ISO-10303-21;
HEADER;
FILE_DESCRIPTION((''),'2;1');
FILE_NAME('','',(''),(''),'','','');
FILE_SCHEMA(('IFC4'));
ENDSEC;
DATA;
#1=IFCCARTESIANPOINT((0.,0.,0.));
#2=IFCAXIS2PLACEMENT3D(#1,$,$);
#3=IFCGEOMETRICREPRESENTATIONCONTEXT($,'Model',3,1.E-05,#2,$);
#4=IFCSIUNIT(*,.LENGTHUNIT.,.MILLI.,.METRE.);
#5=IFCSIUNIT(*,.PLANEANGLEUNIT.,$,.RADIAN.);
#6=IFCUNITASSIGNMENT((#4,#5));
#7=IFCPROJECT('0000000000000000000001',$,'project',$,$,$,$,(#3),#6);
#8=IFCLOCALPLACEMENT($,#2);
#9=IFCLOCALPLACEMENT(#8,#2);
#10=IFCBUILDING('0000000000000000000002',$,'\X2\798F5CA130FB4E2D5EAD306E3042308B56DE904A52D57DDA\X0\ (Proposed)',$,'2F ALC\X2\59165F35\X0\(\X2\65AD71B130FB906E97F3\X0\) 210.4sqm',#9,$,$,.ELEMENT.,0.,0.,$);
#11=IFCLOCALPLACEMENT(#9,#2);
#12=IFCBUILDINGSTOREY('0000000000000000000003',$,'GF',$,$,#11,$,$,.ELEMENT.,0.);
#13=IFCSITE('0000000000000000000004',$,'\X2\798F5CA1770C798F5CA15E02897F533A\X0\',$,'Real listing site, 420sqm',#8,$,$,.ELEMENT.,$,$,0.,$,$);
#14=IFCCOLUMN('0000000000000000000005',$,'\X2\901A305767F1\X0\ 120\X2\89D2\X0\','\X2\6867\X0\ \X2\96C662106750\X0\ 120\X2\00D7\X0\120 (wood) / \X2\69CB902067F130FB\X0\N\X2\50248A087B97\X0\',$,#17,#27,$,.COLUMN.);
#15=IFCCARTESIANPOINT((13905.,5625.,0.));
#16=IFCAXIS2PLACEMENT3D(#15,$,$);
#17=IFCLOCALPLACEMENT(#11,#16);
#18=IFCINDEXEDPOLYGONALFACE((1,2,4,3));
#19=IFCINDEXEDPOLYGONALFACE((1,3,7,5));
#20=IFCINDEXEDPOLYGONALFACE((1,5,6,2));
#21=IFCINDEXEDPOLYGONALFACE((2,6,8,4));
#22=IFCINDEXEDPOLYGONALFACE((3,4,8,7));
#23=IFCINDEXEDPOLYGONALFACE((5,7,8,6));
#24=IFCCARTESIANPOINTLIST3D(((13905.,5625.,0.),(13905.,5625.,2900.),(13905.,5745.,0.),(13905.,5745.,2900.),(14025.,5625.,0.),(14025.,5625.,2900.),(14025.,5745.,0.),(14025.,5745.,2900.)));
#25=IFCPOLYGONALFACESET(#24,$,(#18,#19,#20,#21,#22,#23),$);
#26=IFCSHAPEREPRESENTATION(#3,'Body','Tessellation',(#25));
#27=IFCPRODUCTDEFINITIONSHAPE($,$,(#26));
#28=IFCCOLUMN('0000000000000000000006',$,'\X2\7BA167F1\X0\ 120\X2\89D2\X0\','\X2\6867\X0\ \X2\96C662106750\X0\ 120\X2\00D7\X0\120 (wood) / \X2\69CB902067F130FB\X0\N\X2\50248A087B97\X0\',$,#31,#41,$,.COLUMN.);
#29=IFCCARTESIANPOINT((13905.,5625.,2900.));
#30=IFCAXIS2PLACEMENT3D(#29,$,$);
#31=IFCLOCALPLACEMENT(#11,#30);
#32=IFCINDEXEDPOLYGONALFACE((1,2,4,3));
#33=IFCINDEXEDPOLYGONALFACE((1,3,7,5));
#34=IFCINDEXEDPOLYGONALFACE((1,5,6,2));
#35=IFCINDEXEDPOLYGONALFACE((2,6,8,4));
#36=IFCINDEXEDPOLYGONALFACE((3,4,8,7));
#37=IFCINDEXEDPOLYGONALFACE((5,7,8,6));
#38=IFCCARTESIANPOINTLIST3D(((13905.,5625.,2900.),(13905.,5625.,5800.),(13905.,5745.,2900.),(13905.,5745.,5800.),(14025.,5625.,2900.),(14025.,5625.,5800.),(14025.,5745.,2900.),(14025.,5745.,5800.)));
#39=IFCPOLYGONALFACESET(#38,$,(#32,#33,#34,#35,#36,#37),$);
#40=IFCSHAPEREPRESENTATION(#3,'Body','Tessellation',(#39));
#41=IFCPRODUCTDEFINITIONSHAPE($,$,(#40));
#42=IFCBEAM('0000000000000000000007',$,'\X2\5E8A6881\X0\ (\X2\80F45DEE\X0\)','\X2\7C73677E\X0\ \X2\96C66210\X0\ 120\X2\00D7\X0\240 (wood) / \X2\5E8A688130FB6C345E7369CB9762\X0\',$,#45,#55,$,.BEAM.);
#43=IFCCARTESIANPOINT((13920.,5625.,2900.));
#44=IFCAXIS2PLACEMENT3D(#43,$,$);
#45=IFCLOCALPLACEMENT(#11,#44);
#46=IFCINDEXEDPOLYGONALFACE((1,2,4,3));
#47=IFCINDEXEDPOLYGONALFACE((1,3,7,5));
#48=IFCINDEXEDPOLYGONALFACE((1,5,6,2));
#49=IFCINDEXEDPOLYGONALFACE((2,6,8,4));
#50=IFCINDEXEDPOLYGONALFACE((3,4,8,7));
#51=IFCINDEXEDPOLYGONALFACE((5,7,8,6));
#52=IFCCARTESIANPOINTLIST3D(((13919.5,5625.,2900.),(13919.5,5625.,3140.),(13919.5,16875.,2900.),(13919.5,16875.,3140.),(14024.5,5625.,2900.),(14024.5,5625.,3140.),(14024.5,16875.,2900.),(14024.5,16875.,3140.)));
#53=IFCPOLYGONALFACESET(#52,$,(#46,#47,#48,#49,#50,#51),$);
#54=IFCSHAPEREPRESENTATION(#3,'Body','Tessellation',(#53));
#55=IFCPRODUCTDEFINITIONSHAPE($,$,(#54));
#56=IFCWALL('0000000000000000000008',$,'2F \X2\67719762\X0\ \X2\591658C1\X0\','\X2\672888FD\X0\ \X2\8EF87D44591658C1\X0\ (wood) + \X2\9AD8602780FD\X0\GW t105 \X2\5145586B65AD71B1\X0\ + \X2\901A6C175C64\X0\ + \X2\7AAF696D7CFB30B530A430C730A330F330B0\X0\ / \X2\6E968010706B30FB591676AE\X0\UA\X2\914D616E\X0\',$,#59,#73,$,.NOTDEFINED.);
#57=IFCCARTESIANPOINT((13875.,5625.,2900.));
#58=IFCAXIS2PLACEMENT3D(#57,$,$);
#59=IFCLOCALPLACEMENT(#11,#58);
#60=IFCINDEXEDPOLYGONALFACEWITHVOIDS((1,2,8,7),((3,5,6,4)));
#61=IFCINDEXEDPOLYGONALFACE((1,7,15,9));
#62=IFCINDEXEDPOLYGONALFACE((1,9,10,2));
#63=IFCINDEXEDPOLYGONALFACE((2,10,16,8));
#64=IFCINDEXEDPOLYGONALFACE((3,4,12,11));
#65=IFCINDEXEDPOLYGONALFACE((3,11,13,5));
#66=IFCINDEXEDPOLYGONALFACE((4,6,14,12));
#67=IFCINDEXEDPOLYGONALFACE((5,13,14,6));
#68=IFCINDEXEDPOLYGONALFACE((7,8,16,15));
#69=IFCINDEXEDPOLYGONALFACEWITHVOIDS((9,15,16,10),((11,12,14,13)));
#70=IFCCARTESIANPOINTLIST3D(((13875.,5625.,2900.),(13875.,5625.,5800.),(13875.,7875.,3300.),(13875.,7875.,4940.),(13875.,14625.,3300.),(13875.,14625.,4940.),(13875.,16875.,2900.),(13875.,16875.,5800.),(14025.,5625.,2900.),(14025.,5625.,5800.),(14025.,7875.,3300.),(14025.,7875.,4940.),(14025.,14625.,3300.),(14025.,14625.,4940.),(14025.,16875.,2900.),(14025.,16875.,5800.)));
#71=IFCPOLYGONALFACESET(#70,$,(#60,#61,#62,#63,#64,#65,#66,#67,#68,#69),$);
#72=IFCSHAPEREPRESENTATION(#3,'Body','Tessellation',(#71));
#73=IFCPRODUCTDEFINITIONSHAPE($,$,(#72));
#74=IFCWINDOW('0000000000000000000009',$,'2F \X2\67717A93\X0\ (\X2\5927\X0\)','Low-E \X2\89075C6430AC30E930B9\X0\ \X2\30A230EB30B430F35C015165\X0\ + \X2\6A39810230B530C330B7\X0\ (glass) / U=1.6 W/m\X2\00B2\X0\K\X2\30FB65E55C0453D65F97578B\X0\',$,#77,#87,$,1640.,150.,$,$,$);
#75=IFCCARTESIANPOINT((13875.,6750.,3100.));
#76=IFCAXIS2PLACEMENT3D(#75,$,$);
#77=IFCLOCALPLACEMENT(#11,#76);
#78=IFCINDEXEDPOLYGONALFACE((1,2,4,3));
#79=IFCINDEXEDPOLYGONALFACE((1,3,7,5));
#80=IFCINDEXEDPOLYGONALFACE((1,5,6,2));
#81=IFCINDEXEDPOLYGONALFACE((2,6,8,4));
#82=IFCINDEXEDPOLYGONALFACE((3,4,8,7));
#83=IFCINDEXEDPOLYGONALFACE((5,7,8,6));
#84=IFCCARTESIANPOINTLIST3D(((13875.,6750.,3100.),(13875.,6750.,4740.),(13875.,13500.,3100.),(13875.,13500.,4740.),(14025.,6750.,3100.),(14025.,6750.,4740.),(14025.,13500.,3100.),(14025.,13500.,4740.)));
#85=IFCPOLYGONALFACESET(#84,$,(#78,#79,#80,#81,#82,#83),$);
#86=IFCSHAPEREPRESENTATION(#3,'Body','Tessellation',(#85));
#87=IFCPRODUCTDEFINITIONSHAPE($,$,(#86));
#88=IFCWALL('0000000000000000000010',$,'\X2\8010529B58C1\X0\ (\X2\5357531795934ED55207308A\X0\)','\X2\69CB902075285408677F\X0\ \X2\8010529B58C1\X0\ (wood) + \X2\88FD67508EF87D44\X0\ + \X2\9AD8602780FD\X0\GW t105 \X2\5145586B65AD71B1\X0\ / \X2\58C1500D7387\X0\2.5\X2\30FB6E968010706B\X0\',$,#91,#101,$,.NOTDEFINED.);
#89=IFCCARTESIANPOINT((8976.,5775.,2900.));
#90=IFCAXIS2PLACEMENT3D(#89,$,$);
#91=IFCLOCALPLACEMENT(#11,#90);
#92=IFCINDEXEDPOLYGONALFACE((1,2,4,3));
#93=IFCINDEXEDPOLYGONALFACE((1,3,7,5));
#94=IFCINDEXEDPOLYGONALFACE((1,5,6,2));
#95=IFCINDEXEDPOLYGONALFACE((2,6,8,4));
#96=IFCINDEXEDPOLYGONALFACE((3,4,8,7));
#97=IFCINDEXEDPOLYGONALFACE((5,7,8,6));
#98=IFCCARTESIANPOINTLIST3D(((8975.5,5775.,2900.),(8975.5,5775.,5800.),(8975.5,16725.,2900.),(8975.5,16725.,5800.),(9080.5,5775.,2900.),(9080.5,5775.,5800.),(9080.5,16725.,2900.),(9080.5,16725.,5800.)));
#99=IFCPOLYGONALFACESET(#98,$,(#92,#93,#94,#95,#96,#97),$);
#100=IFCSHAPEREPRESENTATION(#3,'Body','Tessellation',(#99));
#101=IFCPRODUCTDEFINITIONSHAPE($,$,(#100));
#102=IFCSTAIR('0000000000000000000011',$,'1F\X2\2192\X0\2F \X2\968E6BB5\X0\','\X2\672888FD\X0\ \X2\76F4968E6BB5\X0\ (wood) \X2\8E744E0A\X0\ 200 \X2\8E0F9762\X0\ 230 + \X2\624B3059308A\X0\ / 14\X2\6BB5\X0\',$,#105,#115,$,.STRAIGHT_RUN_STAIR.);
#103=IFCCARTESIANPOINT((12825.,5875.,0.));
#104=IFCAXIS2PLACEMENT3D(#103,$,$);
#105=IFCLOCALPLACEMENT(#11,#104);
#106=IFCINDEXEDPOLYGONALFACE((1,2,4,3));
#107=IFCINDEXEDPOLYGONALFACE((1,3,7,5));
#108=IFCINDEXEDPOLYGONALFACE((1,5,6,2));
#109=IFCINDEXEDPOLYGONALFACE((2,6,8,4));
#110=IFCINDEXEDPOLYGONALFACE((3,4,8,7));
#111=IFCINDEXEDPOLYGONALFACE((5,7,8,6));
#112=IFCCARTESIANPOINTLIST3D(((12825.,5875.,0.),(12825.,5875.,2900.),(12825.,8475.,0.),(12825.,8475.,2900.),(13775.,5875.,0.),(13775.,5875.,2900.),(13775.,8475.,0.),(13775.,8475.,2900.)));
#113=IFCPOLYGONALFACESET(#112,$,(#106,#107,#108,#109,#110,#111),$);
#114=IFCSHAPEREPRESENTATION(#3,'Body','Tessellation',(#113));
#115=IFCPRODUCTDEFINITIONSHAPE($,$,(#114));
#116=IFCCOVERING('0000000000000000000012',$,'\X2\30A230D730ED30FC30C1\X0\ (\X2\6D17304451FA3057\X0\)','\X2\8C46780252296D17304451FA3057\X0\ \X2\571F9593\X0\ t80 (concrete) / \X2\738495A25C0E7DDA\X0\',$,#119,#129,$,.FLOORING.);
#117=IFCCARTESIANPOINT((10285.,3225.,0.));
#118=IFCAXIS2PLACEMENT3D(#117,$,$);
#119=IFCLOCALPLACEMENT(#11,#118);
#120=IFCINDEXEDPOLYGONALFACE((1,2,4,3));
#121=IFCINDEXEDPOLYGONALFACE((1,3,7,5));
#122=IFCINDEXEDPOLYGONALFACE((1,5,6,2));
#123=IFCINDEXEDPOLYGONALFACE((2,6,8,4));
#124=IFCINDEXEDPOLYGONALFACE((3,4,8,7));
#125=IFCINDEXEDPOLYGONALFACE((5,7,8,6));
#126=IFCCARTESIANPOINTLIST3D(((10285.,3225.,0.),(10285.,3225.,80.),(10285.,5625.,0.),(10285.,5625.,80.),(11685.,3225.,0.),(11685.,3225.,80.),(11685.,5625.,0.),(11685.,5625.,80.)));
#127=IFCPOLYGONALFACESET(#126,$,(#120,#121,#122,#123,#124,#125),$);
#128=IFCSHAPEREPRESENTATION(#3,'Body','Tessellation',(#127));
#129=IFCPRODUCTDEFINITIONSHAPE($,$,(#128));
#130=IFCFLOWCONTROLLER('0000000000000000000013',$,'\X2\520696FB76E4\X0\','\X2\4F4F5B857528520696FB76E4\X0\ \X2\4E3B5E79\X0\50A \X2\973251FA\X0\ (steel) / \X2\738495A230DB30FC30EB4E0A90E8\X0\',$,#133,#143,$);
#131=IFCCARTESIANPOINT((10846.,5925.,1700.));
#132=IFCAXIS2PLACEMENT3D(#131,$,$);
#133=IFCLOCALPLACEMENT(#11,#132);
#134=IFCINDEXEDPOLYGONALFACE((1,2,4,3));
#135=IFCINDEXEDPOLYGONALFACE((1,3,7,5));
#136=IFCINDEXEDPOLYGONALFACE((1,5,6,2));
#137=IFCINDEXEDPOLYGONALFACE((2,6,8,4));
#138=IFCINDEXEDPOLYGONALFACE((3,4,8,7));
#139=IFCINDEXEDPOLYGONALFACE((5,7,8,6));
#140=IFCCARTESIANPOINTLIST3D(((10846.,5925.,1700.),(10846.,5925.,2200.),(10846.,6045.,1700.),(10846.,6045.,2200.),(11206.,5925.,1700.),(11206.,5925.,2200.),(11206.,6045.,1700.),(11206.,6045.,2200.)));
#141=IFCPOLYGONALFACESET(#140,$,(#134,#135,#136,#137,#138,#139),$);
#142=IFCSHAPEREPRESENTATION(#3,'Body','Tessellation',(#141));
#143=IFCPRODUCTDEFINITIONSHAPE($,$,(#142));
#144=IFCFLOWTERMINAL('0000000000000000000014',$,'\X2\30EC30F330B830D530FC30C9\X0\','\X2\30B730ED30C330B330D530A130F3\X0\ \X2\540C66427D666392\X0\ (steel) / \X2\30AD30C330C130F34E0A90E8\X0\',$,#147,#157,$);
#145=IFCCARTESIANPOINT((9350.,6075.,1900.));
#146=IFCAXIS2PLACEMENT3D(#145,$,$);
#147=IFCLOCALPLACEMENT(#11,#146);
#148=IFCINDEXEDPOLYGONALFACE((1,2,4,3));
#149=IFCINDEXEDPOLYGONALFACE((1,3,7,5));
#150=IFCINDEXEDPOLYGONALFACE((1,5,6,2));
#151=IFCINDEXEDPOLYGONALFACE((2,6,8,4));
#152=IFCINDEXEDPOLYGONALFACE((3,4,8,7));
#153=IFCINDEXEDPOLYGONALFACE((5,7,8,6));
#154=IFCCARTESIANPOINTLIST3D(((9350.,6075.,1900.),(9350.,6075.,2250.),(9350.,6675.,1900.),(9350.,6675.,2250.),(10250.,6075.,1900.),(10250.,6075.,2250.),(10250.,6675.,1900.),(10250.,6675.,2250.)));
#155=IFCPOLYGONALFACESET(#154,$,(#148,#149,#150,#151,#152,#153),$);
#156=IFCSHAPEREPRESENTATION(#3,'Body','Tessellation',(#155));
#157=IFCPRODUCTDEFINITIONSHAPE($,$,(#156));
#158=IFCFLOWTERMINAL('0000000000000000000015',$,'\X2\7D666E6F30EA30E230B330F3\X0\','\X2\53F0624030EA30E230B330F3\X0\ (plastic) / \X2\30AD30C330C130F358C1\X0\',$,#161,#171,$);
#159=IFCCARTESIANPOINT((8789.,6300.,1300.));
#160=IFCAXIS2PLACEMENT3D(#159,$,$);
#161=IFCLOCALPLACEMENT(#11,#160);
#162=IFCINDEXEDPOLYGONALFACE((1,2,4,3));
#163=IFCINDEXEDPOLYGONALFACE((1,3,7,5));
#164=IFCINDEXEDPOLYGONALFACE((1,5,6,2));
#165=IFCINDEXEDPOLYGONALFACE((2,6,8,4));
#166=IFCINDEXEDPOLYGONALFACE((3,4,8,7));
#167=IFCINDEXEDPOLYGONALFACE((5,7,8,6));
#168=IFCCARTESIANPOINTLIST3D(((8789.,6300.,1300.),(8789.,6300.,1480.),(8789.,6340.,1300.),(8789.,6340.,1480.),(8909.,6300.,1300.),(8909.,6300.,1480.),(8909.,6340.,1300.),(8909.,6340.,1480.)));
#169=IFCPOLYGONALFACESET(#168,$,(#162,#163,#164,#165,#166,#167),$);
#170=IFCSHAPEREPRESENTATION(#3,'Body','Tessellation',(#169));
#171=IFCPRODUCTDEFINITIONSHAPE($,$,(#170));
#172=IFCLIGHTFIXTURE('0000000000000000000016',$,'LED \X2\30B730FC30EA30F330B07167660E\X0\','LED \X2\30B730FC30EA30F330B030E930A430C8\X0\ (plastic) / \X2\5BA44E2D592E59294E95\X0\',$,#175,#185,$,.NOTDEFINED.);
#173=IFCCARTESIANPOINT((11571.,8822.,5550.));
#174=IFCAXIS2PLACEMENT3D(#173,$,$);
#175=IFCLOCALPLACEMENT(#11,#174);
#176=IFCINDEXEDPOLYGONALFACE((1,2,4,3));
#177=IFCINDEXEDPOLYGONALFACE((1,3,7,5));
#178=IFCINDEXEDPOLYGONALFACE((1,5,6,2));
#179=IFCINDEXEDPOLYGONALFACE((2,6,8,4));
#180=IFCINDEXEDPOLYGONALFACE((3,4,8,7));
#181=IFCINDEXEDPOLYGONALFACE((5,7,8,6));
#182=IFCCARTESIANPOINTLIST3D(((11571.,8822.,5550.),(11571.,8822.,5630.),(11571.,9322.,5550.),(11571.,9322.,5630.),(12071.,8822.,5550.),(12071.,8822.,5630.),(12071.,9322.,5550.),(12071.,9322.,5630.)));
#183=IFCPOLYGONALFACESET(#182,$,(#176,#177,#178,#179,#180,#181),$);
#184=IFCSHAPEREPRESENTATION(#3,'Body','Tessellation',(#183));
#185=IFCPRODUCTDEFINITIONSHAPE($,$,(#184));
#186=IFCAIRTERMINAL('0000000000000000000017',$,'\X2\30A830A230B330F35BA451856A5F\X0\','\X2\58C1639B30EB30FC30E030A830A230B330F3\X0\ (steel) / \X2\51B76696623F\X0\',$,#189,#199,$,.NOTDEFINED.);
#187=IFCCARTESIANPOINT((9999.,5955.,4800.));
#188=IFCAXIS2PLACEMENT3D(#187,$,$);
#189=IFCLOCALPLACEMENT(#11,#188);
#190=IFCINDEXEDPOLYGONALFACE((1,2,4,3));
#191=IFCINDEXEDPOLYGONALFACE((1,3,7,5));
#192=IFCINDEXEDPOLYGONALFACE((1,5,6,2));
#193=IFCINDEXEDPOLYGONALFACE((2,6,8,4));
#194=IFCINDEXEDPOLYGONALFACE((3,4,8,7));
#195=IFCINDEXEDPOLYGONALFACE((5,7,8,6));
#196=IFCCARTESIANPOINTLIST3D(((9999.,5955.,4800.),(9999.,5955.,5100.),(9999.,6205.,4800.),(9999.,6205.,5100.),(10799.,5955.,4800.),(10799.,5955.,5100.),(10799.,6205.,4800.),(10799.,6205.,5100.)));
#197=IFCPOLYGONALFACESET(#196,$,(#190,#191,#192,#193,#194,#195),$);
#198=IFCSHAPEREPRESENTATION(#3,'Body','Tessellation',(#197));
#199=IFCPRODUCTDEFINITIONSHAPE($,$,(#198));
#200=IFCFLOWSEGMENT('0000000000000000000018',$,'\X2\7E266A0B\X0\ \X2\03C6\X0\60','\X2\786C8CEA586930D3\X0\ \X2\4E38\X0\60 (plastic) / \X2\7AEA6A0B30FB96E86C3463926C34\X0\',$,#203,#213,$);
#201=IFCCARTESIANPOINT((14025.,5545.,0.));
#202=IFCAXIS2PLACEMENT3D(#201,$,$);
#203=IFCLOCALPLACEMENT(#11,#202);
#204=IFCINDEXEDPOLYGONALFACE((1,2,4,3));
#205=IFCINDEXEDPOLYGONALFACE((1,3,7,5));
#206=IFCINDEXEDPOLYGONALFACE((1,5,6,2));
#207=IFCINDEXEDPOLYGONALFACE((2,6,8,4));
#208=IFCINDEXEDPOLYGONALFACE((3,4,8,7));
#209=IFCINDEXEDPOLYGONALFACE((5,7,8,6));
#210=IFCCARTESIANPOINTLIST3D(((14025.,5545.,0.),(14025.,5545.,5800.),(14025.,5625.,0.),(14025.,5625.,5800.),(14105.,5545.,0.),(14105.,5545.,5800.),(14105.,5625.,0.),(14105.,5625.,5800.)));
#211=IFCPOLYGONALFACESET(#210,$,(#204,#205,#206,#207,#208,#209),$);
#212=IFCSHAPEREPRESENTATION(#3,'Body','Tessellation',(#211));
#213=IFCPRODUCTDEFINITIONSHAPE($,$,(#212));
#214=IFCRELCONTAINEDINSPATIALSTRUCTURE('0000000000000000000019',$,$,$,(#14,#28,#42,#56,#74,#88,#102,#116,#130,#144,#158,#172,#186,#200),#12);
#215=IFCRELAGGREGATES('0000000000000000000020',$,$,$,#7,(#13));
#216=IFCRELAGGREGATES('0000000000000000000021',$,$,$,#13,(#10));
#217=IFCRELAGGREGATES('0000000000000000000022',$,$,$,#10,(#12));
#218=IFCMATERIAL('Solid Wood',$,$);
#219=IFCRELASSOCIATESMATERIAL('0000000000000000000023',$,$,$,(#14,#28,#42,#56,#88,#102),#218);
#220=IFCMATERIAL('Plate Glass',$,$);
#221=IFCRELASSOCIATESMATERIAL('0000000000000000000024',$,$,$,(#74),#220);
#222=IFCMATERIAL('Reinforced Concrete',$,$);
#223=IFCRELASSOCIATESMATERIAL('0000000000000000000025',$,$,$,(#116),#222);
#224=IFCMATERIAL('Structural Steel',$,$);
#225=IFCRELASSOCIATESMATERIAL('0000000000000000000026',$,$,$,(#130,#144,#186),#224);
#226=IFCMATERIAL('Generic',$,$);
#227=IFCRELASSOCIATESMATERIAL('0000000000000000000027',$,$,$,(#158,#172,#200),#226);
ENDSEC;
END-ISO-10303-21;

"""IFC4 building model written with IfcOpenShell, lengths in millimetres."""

from ifc_helpers import new_model, si_unit, frame, frame_2d, origin, place, context, project, spatial, rectangle, extrude, material, element, fill, save


model = new_model("IFC4")

# Units and contexts
model_context = context("Model", 3, precision=1e-05, world=origin())
ifc_project = project(units=[si_unit("LENGTHUNIT", "METRE", prefix="MILLI"), si_unit("PLANEANGLEUNIT", "RADIAN")], contexts=[model_context])

# Site, building, storey
site_placement = place(None, origin())
site = spatial("IfcSite", under=ifc_project, at=site_placement, Name="福岡県福岡市西区", ObjectType="Real listing site, 420sqm", CompositionType="ELEMENT", RefElevation=0.0)
building_placement = place(site_placement, origin())
building = spatial("IfcBuilding", under=site, at=building_placement, Name="福岡・中庭のある回遊動線 (Proposed)", ObjectType="2F ALC外張(断熱・遮音) 210.4sqm", CompositionType="ELEMENT", ElevationOfRefHeight=0.0, ElevationOfTerrain=0.0)
storey_placement = place(building_placement, origin())
storey = spatial("IfcBuildingStorey", under=building, at=storey_placement, Name="GF", CompositionType="ELEMENT", Elevation=0.0)

# Columns
ifc_material_1 = material(Name="Solid Wood")
column_1_placement = place(storey_placement, frame((13905.0, 5625.0, 0.0)))
element("IfcColumn", 1, at=column_1_placement, inside=storey, material=ifc_material_1, Name="通し柱 120角", Description="桧 集成材 120×120 (wood) / 構造柱・N値計算", PredefinedType="COLUMN", context=model_context, shape_type="SweptSolid", body=[
    extrude(rectangle(XDim=120.0, YDim=120.0, at=frame_2d((60.0, 60.0))), frame((13905.0, 5625.0, 0.0)), (0.0, 0.0, 1.0), 2900.0),
])
column_2_placement = place(storey_placement, frame((13905.0, 5625.0, 2900.0)))
element("IfcColumn", 2, at=column_2_placement, inside=storey, material=ifc_material_1, Name="管柱 120角", Description="桧 集成材 120×120 (wood) / 構造柱・N値計算", PredefinedType="COLUMN", context=model_context, shape_type="SweptSolid", body=[
    extrude(rectangle(XDim=120.0, YDim=120.0, at=frame_2d((60.0, 60.0))), frame((13905.0, 5625.0, 2900.0)), (0.0, 0.0, 1.0), 2900.0),
])

# Beam
beam_1_placement = place(storey_placement, frame((13920.0, 5625.0, 2900.0)))
element("IfcBeam", 3, at=beam_1_placement, inside=storey, material=ifc_material_1, Name="床梁 (胴差)", Description="米松 集成 120×240 (wood) / 床梁・水平構面", PredefinedType="BEAM", context=model_context, shape_type="SweptSolid", body=[
    extrude(rectangle(XDim=105.0, YDim=11250.0, at=frame_2d((52.0, 5625.0))), frame((13920.0, 5625.0, 2900.0)), (0.0, 0.0, 1.0), 240.0),
])

# Shared definitions
ifc_material_2 = material(Name="Plate Glass")

# Wall, opening, window
wall_1_placement = place(storey_placement, frame((13875.0, 5625.0, 2900.0)))
wall_1 = element("IfcWall", 4, at=wall_1_placement, inside=storey, material=ifc_material_1, Name="2F 東面 外壁", Description="木製 軸組外壁 (wood) + 高性能GW t105 充填断熱 + 通気層 + 窯業系サイディング / 準耐火・外皮UA配慮", PredefinedType="NOTDEFINED", context=model_context, shape_type="SweptSolid", body=[
    extrude(rectangle(XDim=150.0, YDim=11250.0, at=frame_2d((75.0, 5625.0))), frame((13875.0, 5625.0, 2900.0)), (0.0, 0.0, 1.0), 2900.0),
])
opening_1_placement = place(storey_placement, frame((13875.0, 6750.0, 3100.0)))
opening_1 = element("IfcOpeningElement", 5, at=opening_1_placement, cuts=wall_1, PredefinedType="NOTDEFINED", context=model_context, shape_type="SweptSolid", body=[
    extrude(rectangle(XDim=150.0, YDim=6750.0, at=frame_2d((75.0, 3375.0))), frame((13875.0, 6750.0, 3100.0)), (0.0, 0.0, 1.0), 1640.0),
])
window_1_placement = place(storey_placement, frame((13875.0, 6750.0, 3100.0)))
window_1 = element("IfcWindow", 6, at=window_1_placement, inside=storey, material=ifc_material_2, Name="2F 東窓 (大)", Description="Low-E 複層ガラス アルゴン封入 + 樹脂サッシ (glass) / U=1.6 W/m²K・日射取得型", OverallHeight=1640.0, OverallWidth=150.0, context=model_context, shape_type="SweptSolid", body=[
    extrude(rectangle(XDim=150.0, YDim=6750.0, at=frame_2d((75.0, 3375.0))), frame((13875.0, 6750.0, 3100.0)), (0.0, 0.0, 1.0), 1640.0),
])
fill(opening_1, window_1)

# Wall
wall_2_placement = place(storey_placement, frame((8976.0, 5775.0, 2900.0)))
element("IfcWall", 7, at=wall_2_placement, inside=storey, material=ifc_material_1, Name="耐力壁 (南北間仕切り)", Description="構造用合板 耐力壁 (wood) + 製材軸組 + 高性能GW t105 充填断熱 / 壁倍率2.5・準耐火", PredefinedType="NOTDEFINED", context=model_context, shape_type="SweptSolid", body=[
    extrude(rectangle(XDim=105.0, YDim=10950.0, at=frame_2d((52.0, 5475.0))), frame((8976.0, 5775.0, 2900.0)), (0.0, 0.0, 1.0), 2900.0),
])

# Stair
stair_placement = place(storey_placement, frame((12825.0, 5875.0, 0.0)))
element("IfcStair", 8, at=stair_placement, inside=storey, material=ifc_material_1, Name="1F→2F 階段", Description="木製 直階段 (wood) 蹴上 200 踏面 230 + 手すり / 14段", PredefinedType="STRAIGHT_RUN_STAIR", context=model_context, shape_type="SweptSolid", body=[
    extrude(rectangle(XDim=950.0, YDim=2600.0, at=frame_2d((475.0, 1300.0))), frame((12825.0, 5875.0, 0.0)), (0.0, 0.0, 1.0), 2900.0),
])

# Covering
ifc_material_3 = material(Name="Reinforced Concrete")
covering_placement = place(storey_placement, frame((10285.0, 3225.0, 0.0)))
element("IfcCovering", 9, at=covering_placement, inside=storey, material=ifc_material_3, Name="アプローチ (洗い出し)", Description="豆砂利洗い出し 土間 t80 (concrete) / 玄関導線", PredefinedType="FLOORING", context=model_context, shape_type="SweptSolid", body=[
    extrude(rectangle(XDim=1400.0, YDim=2400.0, at=frame_2d((700.0, 1200.0))), frame((10285.0, 3225.0, 0.0)), (0.0, 0.0, 1.0), 80.0),
])

# Flow controller
ifc_material_4 = material(Name="Structural Steel")
flow_controller_placement = place(storey_placement, frame((10846.0, 5925.0, 1700.0)))
element("IfcFlowController", 10, at=flow_controller_placement, inside=storey, material=ifc_material_4, Name="分電盤", Description="住宅用分電盤 主幹50A 露出 (steel) / 玄関ホール上部", context=model_context, shape_type="SweptSolid", body=[
    extrude(rectangle(XDim=360.0, YDim=120.0, at=frame_2d((180.0, 60.0))), frame((10846.0, 5925.0, 1700.0)), (0.0, 0.0, 1.0), 500.0),
])

# Flow terminals
flow_terminal_1_placement = place(storey_placement, frame((9350.0, 6075.0, 1900.0)))
element("IfcFlowTerminal", 11, at=flow_terminal_1_placement, inside=storey, material=ifc_material_4, Name="レンジフード", Description="シロッコファン 同時給排 (steel) / キッチン上部", context=model_context, shape_type="SweptSolid", body=[
    extrude(rectangle(XDim=900.0, YDim=600.0, at=frame_2d((450.0, 300.0))), frame((9350.0, 6075.0, 1900.0)), (0.0, 0.0, 1.0), 350.0),
])
ifc_material_5 = material(Name="Generic")
flow_terminal_2_placement = place(storey_placement, frame((8789.0, 6300.0, 1300.0)))
element("IfcFlowTerminal", 12, at=flow_terminal_2_placement, inside=storey, material=ifc_material_5, Name="給湯リモコン", Description="台所リモコン (plastic) / キッチン壁", context=model_context, shape_type="SweptSolid", body=[
    extrude(rectangle(XDim=120.0, YDim=40.0, at=frame_2d((60.0, 20.0))), frame((8789.0, 6300.0, 1300.0)), (0.0, 0.0, 1.0), 180.0),
])

# Light fixture
light_fixture_placement = place(storey_placement, frame((11571.0, 8822.0, 5550.0)))
element("IfcLightFixture", 13, at=light_fixture_placement, inside=storey, material=ifc_material_5, Name="LED シーリング照明", Description="LED シーリングライト (plastic) / 室中央天井", PredefinedType="NOTDEFINED", context=model_context, shape_type="SweptSolid", body=[
    extrude(rectangle(XDim=500.0, YDim=500.0, at=frame_2d((250.0, 250.0))), frame((11571.0, 8822.0, 5550.0)), (0.0, 0.0, 1.0), 80.0),
])

# Air terminal
air_terminal_placement = place(storey_placement, frame((9999.0, 5955.0, 4800.0)))
element("IfcAirTerminal", 14, at=air_terminal_placement, inside=storey, material=ifc_material_4, Name="エアコン室内機", Description="壁掛ルームエアコン (steel) / 冷暖房", PredefinedType="NOTDEFINED", context=model_context, shape_type="SweptSolid", body=[
    extrude(rectangle(XDim=800.0, YDim=250.0, at=frame_2d((400.0, 125.0))), frame((9999.0, 5955.0, 4800.0)), (0.0, 0.0, 1.0), 300.0),
])

# Flow segment
flow_segment_placement = place(storey_placement, frame((14025.0, 5545.0, 0.0)))
element("IfcFlowSegment", 15, at=flow_segment_placement, inside=storey, material=ifc_material_5, Name="縦樋 φ60", Description="硬質塩ビ 丸60 (plastic) / 竪樋・雨水排水", context=model_context, shape_type="SweptSolid", body=[
    extrude(rectangle(XDim=80.0, YDim=80.0, at=frame_2d((40.0, 40.0))), frame((14025.0, 5545.0, 0.0)), (0.0, 0.0, 1.0), 5800.0),
])

save(model, "model.ifc")
